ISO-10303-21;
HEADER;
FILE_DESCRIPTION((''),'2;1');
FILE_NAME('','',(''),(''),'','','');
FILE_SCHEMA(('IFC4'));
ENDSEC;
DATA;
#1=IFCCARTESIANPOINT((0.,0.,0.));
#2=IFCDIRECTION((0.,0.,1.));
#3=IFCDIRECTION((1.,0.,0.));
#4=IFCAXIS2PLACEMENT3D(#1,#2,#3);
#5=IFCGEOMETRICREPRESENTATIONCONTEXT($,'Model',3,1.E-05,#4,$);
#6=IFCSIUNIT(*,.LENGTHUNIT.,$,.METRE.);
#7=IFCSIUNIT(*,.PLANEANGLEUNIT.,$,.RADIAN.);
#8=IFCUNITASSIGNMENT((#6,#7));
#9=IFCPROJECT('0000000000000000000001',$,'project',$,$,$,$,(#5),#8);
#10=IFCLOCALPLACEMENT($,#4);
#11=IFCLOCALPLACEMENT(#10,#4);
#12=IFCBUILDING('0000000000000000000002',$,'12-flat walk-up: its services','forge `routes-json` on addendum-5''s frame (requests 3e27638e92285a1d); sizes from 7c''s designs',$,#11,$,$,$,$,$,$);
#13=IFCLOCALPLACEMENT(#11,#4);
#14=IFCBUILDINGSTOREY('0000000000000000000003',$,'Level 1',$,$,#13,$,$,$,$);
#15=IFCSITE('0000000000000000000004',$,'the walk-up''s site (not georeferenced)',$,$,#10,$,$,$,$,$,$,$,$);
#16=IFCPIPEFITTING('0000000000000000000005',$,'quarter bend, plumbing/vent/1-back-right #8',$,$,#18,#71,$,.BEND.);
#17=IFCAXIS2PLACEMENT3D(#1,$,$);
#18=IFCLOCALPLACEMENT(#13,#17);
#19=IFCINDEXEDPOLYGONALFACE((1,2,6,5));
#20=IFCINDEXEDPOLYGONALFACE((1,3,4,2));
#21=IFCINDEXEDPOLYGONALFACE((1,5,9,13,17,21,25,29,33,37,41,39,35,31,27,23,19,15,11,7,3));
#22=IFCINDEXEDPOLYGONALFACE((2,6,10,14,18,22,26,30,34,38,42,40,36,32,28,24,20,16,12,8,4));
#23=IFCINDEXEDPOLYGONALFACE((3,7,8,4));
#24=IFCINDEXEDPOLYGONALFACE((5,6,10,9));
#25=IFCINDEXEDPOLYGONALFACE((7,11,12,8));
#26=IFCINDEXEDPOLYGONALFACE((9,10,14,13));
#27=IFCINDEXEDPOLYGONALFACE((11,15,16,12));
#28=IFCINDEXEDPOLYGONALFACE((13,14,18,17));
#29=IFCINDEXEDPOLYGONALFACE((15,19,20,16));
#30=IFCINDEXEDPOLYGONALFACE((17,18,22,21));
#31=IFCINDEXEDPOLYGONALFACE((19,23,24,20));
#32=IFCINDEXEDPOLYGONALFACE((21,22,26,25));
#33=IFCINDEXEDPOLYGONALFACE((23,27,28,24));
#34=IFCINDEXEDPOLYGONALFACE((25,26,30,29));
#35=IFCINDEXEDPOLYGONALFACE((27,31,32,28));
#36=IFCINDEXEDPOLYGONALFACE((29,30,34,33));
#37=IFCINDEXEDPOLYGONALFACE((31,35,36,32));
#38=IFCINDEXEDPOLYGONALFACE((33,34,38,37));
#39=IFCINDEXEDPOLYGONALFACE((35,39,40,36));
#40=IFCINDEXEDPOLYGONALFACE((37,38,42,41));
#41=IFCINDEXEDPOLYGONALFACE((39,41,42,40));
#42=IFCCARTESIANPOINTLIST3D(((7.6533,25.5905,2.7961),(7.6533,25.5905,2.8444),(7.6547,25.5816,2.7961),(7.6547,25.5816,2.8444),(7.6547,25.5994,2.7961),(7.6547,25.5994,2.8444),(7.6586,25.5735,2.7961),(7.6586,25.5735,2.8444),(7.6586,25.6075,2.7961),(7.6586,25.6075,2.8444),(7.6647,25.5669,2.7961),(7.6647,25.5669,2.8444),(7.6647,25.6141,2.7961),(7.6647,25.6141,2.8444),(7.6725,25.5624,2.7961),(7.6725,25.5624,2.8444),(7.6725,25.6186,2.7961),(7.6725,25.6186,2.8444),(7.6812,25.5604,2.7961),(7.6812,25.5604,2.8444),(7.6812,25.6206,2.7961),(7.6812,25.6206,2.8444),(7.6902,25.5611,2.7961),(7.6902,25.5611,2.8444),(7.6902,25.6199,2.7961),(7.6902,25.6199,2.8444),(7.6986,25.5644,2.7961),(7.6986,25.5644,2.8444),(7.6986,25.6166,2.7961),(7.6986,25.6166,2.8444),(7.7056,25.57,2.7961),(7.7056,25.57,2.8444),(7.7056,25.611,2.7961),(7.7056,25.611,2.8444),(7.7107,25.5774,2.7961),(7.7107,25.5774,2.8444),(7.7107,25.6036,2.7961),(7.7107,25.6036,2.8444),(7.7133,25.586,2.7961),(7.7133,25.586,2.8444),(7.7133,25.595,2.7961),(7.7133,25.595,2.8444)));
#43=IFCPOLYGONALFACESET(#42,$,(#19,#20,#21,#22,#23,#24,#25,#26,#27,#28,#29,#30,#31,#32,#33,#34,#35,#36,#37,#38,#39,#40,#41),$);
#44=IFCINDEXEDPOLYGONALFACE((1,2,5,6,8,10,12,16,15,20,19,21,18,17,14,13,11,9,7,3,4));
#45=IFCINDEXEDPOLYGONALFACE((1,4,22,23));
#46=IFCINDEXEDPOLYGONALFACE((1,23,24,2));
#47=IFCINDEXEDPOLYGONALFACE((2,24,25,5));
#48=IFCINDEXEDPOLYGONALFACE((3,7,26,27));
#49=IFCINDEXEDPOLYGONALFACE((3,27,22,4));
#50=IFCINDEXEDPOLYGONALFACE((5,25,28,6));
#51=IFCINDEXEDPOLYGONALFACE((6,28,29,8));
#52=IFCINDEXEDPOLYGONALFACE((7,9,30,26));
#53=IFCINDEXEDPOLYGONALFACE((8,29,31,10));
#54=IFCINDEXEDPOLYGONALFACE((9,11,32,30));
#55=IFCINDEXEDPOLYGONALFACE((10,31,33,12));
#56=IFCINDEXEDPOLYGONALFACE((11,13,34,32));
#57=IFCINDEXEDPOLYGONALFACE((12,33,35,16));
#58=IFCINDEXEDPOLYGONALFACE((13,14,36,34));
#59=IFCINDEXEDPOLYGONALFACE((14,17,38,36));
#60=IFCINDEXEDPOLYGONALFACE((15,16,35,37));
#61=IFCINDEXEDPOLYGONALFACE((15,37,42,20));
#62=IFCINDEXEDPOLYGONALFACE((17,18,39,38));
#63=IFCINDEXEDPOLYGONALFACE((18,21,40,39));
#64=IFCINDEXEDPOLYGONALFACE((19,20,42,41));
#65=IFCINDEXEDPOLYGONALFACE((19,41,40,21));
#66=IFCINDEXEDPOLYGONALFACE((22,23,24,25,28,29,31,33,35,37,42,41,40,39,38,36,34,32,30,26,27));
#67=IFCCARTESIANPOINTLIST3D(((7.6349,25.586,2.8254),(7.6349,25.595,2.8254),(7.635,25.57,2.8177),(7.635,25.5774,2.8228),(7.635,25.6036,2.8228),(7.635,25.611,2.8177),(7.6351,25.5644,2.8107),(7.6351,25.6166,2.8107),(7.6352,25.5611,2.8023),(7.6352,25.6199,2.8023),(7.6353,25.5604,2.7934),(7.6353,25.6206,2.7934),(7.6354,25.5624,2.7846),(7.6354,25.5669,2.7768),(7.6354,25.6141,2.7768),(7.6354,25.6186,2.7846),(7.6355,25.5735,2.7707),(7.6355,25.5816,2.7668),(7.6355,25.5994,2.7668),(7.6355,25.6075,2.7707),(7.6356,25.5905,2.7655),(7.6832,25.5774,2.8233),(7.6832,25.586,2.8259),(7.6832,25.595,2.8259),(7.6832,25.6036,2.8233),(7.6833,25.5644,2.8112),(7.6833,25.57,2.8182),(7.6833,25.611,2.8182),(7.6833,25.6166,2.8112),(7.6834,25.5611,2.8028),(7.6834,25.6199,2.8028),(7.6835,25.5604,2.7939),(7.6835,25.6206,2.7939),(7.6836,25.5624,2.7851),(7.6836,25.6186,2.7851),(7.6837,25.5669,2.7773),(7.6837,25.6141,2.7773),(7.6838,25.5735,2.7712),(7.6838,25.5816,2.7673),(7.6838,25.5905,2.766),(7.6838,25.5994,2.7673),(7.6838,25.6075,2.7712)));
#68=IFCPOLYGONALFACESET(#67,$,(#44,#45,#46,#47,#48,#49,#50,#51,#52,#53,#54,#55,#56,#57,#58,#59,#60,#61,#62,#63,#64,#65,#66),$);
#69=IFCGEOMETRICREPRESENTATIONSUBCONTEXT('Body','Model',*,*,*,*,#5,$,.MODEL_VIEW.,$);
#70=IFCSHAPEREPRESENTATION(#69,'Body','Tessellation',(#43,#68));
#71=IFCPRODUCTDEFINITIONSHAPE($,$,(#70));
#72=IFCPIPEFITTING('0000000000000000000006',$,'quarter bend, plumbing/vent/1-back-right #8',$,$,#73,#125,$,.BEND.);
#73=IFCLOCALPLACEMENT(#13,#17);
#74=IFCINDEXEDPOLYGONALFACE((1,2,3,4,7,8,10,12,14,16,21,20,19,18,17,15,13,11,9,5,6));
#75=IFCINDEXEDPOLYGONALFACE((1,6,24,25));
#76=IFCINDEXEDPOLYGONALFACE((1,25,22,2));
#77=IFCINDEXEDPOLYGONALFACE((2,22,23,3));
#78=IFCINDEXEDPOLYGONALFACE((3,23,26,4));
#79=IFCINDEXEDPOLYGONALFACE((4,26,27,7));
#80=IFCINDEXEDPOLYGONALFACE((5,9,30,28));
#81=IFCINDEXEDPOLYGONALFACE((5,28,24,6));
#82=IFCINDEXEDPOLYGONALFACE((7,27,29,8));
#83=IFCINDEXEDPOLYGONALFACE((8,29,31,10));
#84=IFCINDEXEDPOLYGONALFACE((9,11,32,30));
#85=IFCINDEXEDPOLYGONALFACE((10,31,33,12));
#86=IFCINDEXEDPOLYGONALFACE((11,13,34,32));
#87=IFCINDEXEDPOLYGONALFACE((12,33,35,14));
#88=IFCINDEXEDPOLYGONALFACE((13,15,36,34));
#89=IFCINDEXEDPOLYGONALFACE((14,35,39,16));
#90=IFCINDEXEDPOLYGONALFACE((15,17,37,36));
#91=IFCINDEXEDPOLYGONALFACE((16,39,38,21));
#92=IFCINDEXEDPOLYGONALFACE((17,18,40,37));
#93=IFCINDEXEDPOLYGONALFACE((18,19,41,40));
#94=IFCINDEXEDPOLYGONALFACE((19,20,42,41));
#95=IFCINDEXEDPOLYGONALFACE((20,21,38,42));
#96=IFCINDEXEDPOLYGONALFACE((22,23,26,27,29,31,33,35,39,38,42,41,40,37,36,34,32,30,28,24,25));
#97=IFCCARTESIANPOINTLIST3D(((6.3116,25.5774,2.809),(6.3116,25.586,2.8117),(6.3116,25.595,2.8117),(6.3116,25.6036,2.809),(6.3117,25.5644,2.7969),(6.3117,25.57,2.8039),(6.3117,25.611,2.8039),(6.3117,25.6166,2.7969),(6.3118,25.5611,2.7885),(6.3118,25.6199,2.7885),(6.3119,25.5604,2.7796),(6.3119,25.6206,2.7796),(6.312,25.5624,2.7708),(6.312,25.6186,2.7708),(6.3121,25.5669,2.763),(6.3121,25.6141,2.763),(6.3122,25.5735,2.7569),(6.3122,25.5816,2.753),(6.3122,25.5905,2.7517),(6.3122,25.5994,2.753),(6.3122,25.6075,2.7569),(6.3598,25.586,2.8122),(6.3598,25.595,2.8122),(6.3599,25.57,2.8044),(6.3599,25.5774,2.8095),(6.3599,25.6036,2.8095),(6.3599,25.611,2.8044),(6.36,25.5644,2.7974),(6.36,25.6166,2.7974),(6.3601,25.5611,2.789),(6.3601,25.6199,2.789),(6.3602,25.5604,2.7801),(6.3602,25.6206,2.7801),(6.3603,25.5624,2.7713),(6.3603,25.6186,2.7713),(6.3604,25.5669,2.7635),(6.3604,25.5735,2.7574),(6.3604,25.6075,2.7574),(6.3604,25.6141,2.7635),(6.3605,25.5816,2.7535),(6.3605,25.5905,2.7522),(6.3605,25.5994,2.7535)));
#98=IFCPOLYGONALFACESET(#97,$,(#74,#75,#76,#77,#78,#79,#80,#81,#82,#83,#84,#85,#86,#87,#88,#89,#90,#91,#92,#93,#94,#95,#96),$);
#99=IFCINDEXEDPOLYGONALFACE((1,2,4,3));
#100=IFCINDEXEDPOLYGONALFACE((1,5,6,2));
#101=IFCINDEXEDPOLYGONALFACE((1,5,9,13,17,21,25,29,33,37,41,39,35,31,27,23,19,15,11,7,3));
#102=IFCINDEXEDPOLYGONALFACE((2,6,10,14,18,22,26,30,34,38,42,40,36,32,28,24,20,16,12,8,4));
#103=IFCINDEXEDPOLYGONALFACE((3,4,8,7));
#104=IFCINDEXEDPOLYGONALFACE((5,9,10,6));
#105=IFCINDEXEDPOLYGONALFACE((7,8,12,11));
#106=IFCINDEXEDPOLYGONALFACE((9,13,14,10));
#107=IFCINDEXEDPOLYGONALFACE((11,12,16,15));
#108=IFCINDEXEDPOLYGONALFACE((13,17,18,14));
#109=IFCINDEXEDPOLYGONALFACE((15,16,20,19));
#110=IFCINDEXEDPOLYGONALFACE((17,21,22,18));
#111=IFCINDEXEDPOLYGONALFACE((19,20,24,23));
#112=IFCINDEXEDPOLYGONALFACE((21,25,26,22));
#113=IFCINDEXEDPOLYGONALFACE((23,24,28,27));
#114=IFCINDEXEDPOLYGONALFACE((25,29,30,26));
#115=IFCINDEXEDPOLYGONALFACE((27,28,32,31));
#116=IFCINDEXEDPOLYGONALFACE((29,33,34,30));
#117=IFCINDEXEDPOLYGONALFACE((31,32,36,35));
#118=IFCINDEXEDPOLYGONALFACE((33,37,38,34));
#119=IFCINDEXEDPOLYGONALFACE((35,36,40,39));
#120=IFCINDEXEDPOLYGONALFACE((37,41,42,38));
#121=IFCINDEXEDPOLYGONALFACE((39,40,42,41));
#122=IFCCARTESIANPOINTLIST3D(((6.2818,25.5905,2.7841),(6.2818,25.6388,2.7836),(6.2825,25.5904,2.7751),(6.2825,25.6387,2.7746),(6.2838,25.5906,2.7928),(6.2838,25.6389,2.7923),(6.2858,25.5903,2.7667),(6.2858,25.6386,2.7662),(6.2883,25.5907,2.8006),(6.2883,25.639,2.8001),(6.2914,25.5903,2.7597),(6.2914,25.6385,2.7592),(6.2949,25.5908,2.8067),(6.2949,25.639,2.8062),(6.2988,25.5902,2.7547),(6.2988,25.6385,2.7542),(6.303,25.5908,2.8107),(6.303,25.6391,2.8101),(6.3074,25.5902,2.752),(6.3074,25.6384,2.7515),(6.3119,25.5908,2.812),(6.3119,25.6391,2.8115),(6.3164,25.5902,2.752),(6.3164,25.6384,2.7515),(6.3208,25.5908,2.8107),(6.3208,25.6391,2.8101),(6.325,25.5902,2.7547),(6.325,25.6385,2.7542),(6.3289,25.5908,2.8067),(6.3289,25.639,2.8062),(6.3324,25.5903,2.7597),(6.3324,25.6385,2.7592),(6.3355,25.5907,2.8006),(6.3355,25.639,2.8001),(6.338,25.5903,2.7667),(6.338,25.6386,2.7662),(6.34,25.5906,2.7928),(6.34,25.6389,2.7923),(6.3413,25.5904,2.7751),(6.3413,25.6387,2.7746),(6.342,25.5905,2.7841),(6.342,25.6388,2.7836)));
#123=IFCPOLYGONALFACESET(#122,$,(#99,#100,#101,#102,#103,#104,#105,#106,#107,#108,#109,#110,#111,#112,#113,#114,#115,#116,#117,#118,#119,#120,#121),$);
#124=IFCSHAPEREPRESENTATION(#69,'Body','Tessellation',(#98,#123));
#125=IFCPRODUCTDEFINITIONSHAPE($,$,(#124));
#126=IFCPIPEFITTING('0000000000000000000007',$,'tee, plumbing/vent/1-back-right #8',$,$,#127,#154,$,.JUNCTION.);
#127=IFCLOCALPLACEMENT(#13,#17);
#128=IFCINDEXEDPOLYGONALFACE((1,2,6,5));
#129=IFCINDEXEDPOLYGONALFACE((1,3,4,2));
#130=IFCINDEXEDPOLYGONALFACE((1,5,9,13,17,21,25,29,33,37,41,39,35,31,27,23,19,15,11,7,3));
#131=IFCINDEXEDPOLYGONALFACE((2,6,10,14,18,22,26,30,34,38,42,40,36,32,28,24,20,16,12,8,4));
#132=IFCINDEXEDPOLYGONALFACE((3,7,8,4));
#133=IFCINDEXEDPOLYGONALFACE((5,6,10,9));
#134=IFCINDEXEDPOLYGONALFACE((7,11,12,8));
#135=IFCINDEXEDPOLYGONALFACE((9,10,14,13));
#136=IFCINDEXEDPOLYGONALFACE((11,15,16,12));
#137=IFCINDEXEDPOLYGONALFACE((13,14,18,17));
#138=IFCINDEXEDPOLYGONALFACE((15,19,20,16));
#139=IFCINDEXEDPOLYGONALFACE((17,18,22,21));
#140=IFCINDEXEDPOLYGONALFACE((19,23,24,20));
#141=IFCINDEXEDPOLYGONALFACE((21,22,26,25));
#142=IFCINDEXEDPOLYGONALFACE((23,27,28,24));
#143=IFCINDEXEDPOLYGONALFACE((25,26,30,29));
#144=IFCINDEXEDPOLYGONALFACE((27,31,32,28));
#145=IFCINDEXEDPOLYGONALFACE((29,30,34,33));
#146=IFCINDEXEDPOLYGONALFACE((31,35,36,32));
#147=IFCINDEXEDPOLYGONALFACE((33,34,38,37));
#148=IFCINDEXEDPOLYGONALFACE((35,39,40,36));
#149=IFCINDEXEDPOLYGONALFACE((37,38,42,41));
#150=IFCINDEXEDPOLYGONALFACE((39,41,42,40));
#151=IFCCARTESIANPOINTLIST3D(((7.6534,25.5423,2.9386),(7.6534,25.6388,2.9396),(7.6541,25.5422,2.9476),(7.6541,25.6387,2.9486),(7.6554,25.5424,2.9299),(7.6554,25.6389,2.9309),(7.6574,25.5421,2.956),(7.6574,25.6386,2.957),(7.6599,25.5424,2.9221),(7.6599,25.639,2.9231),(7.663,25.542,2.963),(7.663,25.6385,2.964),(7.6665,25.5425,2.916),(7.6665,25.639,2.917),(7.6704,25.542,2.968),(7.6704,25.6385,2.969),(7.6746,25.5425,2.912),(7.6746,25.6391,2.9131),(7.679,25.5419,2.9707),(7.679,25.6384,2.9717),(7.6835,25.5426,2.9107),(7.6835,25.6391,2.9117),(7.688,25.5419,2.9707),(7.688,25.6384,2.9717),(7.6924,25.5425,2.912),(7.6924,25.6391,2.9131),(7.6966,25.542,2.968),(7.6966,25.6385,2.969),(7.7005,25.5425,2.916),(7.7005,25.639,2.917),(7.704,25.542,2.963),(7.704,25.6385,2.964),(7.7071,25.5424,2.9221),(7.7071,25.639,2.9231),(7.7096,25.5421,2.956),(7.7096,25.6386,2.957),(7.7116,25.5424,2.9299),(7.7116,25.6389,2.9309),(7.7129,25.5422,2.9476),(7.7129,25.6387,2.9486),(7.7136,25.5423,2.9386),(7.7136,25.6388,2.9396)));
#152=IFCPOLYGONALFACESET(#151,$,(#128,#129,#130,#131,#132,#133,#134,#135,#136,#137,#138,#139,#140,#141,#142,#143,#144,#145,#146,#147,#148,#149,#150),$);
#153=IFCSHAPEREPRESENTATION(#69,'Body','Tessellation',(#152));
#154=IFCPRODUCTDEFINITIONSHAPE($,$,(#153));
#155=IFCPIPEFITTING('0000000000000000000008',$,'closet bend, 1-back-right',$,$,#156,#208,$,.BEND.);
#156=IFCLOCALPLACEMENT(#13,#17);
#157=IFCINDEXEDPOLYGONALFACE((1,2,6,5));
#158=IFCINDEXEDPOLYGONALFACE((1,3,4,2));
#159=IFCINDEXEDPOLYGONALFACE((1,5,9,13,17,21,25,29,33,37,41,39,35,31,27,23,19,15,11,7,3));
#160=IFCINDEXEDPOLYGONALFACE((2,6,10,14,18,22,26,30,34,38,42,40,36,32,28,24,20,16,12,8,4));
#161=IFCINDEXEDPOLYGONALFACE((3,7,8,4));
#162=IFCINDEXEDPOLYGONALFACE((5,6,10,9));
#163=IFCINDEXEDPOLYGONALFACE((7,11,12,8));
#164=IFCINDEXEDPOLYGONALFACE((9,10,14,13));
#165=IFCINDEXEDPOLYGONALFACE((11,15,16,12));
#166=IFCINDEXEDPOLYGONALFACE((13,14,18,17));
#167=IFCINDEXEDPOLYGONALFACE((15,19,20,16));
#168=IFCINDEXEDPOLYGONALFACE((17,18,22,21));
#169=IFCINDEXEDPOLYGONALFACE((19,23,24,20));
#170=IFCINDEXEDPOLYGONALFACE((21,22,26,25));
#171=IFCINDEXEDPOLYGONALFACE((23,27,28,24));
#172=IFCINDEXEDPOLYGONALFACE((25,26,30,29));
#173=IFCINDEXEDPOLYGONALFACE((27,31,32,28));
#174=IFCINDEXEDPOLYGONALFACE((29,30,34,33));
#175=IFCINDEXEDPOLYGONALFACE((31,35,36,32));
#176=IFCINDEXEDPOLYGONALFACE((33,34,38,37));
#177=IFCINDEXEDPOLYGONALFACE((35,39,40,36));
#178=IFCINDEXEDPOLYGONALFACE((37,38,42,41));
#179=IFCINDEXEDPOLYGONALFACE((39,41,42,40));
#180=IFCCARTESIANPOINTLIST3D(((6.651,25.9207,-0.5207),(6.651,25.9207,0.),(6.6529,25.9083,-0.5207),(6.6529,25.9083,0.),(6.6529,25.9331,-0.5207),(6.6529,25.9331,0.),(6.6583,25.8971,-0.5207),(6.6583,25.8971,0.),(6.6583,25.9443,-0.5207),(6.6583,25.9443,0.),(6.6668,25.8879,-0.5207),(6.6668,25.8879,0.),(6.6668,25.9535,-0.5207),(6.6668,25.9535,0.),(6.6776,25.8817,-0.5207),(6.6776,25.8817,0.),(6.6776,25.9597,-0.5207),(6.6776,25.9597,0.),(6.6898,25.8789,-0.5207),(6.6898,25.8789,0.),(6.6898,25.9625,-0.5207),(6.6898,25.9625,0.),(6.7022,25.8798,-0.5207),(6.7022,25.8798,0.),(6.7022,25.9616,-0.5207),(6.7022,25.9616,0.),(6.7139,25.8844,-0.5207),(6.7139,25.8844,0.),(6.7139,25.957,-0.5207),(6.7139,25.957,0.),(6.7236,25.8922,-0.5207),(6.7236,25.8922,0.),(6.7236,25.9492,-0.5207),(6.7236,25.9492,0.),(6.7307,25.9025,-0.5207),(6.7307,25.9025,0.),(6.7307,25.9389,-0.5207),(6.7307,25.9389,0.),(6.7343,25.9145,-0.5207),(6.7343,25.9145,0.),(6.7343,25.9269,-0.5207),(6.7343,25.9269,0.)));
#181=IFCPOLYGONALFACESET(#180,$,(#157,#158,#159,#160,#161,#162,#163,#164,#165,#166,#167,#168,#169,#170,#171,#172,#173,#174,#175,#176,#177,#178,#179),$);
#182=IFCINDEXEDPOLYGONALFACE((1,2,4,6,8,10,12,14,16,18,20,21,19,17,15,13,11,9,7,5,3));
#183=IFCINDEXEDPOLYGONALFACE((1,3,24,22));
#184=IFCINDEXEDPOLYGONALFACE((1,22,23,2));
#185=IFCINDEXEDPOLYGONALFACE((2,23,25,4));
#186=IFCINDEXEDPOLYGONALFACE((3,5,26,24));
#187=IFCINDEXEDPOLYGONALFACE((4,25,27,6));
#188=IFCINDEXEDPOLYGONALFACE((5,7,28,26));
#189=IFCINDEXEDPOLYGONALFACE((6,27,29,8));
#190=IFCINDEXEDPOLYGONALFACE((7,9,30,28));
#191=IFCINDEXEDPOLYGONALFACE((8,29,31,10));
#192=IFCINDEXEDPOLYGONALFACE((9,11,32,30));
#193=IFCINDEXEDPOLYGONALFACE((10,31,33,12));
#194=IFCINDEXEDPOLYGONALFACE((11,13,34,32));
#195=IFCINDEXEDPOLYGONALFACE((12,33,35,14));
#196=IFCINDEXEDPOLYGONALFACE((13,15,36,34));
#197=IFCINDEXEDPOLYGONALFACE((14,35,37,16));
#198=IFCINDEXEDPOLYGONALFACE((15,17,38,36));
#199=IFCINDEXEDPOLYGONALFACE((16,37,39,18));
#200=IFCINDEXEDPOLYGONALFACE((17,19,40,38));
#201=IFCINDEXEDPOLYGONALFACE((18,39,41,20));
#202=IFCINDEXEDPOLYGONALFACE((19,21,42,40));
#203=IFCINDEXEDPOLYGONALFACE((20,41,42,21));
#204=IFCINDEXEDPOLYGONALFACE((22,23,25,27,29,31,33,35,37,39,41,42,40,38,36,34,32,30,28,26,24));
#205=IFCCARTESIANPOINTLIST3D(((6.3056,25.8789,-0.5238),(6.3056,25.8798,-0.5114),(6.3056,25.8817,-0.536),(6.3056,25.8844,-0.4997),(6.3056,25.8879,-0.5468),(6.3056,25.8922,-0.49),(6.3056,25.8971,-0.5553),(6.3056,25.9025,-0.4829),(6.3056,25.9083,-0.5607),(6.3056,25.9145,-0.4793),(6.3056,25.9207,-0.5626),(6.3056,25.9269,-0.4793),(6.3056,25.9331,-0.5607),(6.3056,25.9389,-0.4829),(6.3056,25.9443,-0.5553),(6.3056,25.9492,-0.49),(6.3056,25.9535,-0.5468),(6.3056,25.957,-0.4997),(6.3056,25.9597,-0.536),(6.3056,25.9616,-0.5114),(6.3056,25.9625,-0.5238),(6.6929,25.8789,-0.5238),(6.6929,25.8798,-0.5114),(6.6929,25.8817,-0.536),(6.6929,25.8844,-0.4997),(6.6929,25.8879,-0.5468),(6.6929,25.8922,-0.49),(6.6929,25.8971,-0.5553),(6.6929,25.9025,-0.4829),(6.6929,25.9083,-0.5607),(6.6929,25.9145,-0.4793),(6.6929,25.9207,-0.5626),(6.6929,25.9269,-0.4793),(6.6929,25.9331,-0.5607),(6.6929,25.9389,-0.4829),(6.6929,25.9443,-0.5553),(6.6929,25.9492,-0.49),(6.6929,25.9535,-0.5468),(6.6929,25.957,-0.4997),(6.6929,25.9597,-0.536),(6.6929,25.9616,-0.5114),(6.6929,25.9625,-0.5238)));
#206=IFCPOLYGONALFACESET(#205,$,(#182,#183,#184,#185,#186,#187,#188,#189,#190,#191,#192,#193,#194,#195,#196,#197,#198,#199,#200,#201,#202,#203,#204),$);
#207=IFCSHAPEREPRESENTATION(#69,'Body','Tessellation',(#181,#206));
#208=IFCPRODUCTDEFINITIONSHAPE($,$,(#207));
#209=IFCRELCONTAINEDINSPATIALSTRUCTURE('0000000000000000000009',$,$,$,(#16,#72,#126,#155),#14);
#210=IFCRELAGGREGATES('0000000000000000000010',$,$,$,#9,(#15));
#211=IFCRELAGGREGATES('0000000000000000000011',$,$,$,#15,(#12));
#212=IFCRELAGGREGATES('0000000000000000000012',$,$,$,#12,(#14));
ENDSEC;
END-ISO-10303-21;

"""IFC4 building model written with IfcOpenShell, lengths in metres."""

from ifc_helpers import new_model, entity, si_unit, frame, origin_with_axes, place, context, subcontext, project, spatial, element, save


model = new_model("IFC4")

# Units and contexts
model_context = context("Model", 3, precision=1e-05, world=origin_with_axes())
body_context = subcontext(model_context, "Body", "Model", "MODEL_VIEW")
ifc_project = project(units=[si_unit("LENGTHUNIT", "METRE"), si_unit("PLANEANGLEUNIT", "RADIAN")], contexts=[model_context])

# Site, building, storey
site_placement = place(None, origin_with_axes())
site = spatial("IfcSite", under=ifc_project, at=site_placement, Name="the walk-up's site (not georeferenced)")
building_placement = place(site_placement, origin_with_axes())
building = spatial("IfcBuilding", under=site, at=building_placement, Name="12-flat walk-up: its services", Description="forge `routes-json` on addendum-5's frame (requests 3e27638e92285a1d); sizes from 7c's designs")
storey_placement = place(building_placement, origin_with_axes())
storey = spatial("IfcBuildingStorey", under=building, at=storey_placement, Name="Level 1")

# Pipe fittings
pipe_fitting_1_placement = place(storey_placement, frame((7.6835, 25.5905, 2.8444), z_axis=(0.0, 0.0, 1.0), x_axis=(1.0, 0.0, 0.0)))
element("IfcPipeFitting", 1, at=pipe_fitting_1_placement, inside=storey, Name="quarter bend, plumbing/vent/1-back-right #8", PredefinedType="BEND", context=body_context, shape_type="AdvancedSweptSolid", body=[
    entity("IfcSweptDiskSolid", entity("IfcPolyline", [entity("IfcCartesianPoint", [0.0, 0.0, 0.0]), entity("IfcCartesianPoint", [0.0, 0.0, -0.0483])]), 0.0302),
    entity("IfcSweptDiskSolid", entity("IfcPolyline", [entity("IfcCartesianPoint", [0.0, 0.0, -0.0483]), entity("IfcCartesianPoint", [-0.0483, 0.0, -0.0488])]), 0.0302),
])
pipe_fitting_2_placement = place(storey_placement, frame((6.3602, 25.5905, 2.7823), z_axis=(0.0, 0.0, 1.0), x_axis=(1.0, 0.0, 0.0)))
element("IfcPipeFitting", 2, at=pipe_fitting_2_placement, inside=storey, Name="quarter bend, plumbing/vent/1-back-right #8", PredefinedType="BEND", context=body_context, shape_type="AdvancedSweptSolid", body=[
    entity("IfcSweptDiskSolid", entity("IfcPolyline", [entity("IfcCartesianPoint", [0.0, 0.0, 0.0]), entity("IfcCartesianPoint", [-0.0483, 0.0, -0.0005])]), 0.0302),
    entity("IfcSweptDiskSolid", entity("IfcPolyline", [entity("IfcCartesianPoint", [-0.0483, 0.0, -0.0005]), entity("IfcCartesianPoint", [-0.0483, 0.0483, -0.001])]), 0.0302),
])
pipe_fitting_3_placement = place(storey_placement, frame((7.6835, 25.6388, 2.9419), z_axis=(0.0, 0.0, 1.0), x_axis=(1.0, 0.0, 0.0)))
element("IfcPipeFitting", 3, at=pipe_fitting_3_placement, inside=storey, Name="tee, plumbing/vent/1-back-right #8", PredefinedType="JUNCTION", context=body_context, shape_type="AdvancedSweptSolid", body=[
    entity("IfcSweptDiskSolid", entity("IfcPolyline", [entity("IfcCartesianPoint", [0.0, 0.0, 0.0]), entity("IfcCartesianPoint", [0.0, -0.0965, -0.001])]), 0.0302),
])
pipe_fitting_4_placement = place(storey_placement, frame((6.6929, 25.9207, 0.0), z_axis=(0.0, 0.0, 1.0), x_axis=(1.0, 0.0, 0.0)))
element("IfcPipeFitting", 4, at=pipe_fitting_4_placement, inside=storey, Name="closet bend, 1-back-right", PredefinedType="BEND", context=body_context, shape_type="AdvancedSweptSolid", body=[
    entity("IfcSweptDiskSolid", entity("IfcPolyline", [entity("IfcCartesianPoint", [0.0, 0.0, 0.0]), entity("IfcCartesianPoint", [0.0, 0.0, -0.5207])]), 0.0419),
    entity("IfcSweptDiskSolid", entity("IfcPolyline", [entity("IfcCartesianPoint", [0.0, 0.0, -0.5207]), entity("IfcCartesianPoint", [-0.3873, 0.0, -0.5207])]), 0.0419),
])

save(model, "model.ifc")
